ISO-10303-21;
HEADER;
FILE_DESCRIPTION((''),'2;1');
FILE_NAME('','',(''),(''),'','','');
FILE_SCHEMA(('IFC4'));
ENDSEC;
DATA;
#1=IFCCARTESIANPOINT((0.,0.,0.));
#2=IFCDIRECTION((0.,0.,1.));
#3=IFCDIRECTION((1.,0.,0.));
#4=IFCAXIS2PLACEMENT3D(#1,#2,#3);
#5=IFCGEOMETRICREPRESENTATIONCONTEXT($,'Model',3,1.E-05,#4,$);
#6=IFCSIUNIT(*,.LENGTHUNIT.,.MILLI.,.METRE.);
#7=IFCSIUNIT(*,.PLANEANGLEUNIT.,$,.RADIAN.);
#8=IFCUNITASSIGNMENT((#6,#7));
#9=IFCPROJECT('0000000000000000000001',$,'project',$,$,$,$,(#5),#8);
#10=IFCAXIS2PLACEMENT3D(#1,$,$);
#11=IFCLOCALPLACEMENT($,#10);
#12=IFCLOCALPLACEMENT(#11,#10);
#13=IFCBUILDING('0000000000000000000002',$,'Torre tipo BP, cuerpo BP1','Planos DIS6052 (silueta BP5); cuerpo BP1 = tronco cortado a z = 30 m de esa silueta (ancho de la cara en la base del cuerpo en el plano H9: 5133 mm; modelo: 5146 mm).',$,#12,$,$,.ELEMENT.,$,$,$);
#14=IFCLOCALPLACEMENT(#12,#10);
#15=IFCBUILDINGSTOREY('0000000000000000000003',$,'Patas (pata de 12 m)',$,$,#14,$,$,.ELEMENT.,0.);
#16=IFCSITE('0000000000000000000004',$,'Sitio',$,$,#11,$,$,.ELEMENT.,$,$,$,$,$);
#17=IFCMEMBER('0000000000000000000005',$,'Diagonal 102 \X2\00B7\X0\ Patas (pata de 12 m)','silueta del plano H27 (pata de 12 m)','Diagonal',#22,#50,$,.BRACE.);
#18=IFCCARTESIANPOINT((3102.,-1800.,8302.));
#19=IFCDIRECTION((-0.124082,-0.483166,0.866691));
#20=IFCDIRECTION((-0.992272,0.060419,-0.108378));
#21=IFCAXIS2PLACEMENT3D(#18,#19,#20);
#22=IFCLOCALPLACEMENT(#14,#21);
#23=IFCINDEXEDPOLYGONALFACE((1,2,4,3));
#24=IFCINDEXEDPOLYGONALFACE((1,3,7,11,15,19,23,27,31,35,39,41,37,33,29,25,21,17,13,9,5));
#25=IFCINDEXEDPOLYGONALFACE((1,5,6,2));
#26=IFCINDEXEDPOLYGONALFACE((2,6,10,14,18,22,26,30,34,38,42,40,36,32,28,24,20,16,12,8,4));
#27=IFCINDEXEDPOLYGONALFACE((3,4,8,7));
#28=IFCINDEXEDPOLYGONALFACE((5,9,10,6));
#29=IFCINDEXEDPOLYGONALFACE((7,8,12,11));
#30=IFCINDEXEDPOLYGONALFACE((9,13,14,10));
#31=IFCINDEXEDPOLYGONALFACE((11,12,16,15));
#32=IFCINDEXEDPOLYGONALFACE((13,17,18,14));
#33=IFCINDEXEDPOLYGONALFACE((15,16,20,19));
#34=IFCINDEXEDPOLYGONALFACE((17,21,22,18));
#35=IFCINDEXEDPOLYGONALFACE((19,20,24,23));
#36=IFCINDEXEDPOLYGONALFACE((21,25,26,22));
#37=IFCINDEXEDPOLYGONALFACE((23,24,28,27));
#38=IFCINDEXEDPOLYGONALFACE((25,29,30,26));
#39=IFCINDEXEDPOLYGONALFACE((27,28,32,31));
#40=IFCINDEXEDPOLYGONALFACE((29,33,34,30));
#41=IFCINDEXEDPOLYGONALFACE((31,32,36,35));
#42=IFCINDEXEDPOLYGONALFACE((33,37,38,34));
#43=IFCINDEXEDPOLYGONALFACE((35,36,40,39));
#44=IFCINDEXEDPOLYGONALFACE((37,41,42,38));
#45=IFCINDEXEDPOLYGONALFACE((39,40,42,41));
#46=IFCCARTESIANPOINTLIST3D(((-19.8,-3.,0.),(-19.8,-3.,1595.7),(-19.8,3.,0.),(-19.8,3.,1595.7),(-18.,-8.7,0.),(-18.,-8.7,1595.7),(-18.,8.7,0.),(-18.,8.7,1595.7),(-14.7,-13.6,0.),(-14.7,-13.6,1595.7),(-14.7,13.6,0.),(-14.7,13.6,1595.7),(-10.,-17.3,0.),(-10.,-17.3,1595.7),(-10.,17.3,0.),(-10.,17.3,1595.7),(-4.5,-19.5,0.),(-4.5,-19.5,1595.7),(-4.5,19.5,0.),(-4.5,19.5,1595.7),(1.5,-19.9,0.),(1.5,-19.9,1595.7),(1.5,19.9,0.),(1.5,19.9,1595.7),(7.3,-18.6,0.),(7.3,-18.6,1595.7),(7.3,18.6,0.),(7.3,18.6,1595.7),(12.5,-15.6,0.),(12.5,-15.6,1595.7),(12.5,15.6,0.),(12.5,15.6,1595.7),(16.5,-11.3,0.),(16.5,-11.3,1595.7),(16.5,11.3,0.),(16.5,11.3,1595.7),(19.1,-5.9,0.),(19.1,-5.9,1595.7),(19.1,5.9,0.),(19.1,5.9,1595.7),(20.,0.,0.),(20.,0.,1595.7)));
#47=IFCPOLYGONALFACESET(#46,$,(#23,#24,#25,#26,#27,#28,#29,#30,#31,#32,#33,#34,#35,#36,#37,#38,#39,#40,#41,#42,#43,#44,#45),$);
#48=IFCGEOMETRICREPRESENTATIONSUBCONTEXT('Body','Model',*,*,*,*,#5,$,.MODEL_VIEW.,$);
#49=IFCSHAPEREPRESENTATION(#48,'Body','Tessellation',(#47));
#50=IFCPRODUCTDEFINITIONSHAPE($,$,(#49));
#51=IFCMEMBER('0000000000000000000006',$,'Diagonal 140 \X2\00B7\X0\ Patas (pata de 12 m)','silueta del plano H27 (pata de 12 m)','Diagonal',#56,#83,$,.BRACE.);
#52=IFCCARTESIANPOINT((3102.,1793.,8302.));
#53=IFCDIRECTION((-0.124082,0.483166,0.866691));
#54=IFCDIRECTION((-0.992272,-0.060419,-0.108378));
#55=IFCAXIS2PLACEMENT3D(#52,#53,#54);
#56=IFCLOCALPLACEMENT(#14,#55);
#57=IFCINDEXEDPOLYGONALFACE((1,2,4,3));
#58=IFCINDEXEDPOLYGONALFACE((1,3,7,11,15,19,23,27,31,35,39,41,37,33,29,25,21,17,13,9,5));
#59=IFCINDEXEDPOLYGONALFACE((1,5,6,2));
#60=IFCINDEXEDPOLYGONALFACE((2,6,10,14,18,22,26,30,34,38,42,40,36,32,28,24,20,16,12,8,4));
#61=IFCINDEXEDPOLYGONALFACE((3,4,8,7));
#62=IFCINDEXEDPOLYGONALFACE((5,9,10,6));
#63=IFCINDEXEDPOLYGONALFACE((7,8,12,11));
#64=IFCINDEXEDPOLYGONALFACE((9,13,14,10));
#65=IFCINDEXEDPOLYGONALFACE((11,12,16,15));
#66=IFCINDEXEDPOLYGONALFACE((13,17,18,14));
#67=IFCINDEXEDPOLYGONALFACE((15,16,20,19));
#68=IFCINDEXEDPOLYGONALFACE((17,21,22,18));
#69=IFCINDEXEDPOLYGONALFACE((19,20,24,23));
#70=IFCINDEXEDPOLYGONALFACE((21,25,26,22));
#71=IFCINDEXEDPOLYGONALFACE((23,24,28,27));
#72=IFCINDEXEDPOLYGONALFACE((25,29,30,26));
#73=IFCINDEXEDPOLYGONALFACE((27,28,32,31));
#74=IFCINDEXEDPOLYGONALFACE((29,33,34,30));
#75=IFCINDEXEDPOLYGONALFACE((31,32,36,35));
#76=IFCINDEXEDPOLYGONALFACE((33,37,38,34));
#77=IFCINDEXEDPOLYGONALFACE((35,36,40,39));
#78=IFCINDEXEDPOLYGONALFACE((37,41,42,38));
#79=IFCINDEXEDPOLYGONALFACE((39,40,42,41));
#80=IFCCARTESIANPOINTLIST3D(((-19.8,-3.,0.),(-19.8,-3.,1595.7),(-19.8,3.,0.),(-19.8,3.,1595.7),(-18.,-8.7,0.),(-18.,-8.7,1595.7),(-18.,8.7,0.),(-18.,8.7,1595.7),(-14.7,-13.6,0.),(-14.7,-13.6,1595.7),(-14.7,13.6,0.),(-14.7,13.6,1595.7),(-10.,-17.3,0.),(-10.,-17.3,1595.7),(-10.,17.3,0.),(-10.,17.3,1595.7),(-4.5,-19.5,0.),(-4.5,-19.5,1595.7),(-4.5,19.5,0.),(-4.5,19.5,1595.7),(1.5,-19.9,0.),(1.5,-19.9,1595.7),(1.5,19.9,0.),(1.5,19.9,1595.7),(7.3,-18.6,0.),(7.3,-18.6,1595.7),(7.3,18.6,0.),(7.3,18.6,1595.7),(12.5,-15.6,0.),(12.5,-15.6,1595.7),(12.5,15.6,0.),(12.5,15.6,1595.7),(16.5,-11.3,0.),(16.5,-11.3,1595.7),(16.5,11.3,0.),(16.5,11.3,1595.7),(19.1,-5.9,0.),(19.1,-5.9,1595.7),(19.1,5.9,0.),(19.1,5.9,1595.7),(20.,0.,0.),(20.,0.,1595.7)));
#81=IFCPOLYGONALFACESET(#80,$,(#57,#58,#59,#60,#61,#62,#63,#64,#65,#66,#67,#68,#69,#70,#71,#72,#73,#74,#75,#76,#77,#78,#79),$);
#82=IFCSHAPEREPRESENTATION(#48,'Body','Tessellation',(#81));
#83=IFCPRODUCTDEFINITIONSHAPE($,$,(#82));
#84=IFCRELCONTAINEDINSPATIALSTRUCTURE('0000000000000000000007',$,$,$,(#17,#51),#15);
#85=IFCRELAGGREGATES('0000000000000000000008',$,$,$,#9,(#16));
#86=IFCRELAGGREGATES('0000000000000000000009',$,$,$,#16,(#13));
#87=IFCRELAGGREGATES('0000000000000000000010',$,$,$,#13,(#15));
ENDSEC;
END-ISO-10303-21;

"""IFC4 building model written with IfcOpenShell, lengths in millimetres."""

from ifc_helpers import new_model, si_unit, frame, origin, origin_with_axes, place, context, subcontext, project, spatial, circle, extrude, element, save


model = new_model("IFC4")

# Units and contexts
model_context = context("Model", 3, precision=1e-05, world=origin_with_axes())
body_context = subcontext(model_context, "Body", "Model", "MODEL_VIEW")
ifc_project = project(units=[si_unit("LENGTHUNIT", "METRE", prefix="MILLI"), si_unit("PLANEANGLEUNIT", "RADIAN")], contexts=[model_context])

# Site, building, storey
site_placement = place(None, origin())
site = spatial("IfcSite", under=ifc_project, at=site_placement, Name="Sitio", CompositionType="ELEMENT")
building_placement = place(site_placement, origin())
building = spatial("IfcBuilding", under=site, at=building_placement, Name="Torre tipo BP, cuerpo BP1", Description="Planos DIS6052 (silueta BP5); cuerpo BP1 = tronco cortado a z = 30 m de esa silueta (ancho de la cara en la base del cuerpo en el plano H9: 5133 mm; modelo: 5146 mm).", CompositionType="ELEMENT")
storey_placement = place(building_placement, origin())
storey = spatial("IfcBuildingStorey", under=building, at=storey_placement, Name="Patas (pata de 12 m)", CompositionType="ELEMENT", Elevation=0.0)

# Members
member_1_placement = place(storey_placement, frame((3102.0, -1800.0, 8302.0), z_axis=(-0.124082, -0.483166, 0.866691), x_axis=(-0.992272, 0.060419, -0.108378)))
element("IfcMember", 1, at=member_1_placement, inside=storey, Name="Diagonal 102 · Patas (pata de 12 m)", Description="silueta del plano H27 (pata de 12 m)", ObjectType="Diagonal", PredefinedType="BRACE", context=body_context, shape_type="SweptSolid", body=[
    extrude(circle(Radius=20.0), None, (0.0, 0.0, 1.0), 1595.7),
])
member_2_placement = place(storey_placement, frame((3102.0, 1793.0, 8302.0), z_axis=(-0.124082, 0.483166, 0.866691), x_axis=(-0.992272, -0.060419, -0.108378)))
element("IfcMember", 2, at=member_2_placement, inside=storey, Name="Diagonal 140 · Patas (pata de 12 m)", Description="silueta del plano H27 (pata de 12 m)", ObjectType="Diagonal", PredefinedType="BRACE", context=body_context, shape_type="SweptSolid", body=[
    extrude(circle(Radius=20.0), None, (0.0, 0.0, 1.0), 1595.7),
])

save(model, "model.ifc")
